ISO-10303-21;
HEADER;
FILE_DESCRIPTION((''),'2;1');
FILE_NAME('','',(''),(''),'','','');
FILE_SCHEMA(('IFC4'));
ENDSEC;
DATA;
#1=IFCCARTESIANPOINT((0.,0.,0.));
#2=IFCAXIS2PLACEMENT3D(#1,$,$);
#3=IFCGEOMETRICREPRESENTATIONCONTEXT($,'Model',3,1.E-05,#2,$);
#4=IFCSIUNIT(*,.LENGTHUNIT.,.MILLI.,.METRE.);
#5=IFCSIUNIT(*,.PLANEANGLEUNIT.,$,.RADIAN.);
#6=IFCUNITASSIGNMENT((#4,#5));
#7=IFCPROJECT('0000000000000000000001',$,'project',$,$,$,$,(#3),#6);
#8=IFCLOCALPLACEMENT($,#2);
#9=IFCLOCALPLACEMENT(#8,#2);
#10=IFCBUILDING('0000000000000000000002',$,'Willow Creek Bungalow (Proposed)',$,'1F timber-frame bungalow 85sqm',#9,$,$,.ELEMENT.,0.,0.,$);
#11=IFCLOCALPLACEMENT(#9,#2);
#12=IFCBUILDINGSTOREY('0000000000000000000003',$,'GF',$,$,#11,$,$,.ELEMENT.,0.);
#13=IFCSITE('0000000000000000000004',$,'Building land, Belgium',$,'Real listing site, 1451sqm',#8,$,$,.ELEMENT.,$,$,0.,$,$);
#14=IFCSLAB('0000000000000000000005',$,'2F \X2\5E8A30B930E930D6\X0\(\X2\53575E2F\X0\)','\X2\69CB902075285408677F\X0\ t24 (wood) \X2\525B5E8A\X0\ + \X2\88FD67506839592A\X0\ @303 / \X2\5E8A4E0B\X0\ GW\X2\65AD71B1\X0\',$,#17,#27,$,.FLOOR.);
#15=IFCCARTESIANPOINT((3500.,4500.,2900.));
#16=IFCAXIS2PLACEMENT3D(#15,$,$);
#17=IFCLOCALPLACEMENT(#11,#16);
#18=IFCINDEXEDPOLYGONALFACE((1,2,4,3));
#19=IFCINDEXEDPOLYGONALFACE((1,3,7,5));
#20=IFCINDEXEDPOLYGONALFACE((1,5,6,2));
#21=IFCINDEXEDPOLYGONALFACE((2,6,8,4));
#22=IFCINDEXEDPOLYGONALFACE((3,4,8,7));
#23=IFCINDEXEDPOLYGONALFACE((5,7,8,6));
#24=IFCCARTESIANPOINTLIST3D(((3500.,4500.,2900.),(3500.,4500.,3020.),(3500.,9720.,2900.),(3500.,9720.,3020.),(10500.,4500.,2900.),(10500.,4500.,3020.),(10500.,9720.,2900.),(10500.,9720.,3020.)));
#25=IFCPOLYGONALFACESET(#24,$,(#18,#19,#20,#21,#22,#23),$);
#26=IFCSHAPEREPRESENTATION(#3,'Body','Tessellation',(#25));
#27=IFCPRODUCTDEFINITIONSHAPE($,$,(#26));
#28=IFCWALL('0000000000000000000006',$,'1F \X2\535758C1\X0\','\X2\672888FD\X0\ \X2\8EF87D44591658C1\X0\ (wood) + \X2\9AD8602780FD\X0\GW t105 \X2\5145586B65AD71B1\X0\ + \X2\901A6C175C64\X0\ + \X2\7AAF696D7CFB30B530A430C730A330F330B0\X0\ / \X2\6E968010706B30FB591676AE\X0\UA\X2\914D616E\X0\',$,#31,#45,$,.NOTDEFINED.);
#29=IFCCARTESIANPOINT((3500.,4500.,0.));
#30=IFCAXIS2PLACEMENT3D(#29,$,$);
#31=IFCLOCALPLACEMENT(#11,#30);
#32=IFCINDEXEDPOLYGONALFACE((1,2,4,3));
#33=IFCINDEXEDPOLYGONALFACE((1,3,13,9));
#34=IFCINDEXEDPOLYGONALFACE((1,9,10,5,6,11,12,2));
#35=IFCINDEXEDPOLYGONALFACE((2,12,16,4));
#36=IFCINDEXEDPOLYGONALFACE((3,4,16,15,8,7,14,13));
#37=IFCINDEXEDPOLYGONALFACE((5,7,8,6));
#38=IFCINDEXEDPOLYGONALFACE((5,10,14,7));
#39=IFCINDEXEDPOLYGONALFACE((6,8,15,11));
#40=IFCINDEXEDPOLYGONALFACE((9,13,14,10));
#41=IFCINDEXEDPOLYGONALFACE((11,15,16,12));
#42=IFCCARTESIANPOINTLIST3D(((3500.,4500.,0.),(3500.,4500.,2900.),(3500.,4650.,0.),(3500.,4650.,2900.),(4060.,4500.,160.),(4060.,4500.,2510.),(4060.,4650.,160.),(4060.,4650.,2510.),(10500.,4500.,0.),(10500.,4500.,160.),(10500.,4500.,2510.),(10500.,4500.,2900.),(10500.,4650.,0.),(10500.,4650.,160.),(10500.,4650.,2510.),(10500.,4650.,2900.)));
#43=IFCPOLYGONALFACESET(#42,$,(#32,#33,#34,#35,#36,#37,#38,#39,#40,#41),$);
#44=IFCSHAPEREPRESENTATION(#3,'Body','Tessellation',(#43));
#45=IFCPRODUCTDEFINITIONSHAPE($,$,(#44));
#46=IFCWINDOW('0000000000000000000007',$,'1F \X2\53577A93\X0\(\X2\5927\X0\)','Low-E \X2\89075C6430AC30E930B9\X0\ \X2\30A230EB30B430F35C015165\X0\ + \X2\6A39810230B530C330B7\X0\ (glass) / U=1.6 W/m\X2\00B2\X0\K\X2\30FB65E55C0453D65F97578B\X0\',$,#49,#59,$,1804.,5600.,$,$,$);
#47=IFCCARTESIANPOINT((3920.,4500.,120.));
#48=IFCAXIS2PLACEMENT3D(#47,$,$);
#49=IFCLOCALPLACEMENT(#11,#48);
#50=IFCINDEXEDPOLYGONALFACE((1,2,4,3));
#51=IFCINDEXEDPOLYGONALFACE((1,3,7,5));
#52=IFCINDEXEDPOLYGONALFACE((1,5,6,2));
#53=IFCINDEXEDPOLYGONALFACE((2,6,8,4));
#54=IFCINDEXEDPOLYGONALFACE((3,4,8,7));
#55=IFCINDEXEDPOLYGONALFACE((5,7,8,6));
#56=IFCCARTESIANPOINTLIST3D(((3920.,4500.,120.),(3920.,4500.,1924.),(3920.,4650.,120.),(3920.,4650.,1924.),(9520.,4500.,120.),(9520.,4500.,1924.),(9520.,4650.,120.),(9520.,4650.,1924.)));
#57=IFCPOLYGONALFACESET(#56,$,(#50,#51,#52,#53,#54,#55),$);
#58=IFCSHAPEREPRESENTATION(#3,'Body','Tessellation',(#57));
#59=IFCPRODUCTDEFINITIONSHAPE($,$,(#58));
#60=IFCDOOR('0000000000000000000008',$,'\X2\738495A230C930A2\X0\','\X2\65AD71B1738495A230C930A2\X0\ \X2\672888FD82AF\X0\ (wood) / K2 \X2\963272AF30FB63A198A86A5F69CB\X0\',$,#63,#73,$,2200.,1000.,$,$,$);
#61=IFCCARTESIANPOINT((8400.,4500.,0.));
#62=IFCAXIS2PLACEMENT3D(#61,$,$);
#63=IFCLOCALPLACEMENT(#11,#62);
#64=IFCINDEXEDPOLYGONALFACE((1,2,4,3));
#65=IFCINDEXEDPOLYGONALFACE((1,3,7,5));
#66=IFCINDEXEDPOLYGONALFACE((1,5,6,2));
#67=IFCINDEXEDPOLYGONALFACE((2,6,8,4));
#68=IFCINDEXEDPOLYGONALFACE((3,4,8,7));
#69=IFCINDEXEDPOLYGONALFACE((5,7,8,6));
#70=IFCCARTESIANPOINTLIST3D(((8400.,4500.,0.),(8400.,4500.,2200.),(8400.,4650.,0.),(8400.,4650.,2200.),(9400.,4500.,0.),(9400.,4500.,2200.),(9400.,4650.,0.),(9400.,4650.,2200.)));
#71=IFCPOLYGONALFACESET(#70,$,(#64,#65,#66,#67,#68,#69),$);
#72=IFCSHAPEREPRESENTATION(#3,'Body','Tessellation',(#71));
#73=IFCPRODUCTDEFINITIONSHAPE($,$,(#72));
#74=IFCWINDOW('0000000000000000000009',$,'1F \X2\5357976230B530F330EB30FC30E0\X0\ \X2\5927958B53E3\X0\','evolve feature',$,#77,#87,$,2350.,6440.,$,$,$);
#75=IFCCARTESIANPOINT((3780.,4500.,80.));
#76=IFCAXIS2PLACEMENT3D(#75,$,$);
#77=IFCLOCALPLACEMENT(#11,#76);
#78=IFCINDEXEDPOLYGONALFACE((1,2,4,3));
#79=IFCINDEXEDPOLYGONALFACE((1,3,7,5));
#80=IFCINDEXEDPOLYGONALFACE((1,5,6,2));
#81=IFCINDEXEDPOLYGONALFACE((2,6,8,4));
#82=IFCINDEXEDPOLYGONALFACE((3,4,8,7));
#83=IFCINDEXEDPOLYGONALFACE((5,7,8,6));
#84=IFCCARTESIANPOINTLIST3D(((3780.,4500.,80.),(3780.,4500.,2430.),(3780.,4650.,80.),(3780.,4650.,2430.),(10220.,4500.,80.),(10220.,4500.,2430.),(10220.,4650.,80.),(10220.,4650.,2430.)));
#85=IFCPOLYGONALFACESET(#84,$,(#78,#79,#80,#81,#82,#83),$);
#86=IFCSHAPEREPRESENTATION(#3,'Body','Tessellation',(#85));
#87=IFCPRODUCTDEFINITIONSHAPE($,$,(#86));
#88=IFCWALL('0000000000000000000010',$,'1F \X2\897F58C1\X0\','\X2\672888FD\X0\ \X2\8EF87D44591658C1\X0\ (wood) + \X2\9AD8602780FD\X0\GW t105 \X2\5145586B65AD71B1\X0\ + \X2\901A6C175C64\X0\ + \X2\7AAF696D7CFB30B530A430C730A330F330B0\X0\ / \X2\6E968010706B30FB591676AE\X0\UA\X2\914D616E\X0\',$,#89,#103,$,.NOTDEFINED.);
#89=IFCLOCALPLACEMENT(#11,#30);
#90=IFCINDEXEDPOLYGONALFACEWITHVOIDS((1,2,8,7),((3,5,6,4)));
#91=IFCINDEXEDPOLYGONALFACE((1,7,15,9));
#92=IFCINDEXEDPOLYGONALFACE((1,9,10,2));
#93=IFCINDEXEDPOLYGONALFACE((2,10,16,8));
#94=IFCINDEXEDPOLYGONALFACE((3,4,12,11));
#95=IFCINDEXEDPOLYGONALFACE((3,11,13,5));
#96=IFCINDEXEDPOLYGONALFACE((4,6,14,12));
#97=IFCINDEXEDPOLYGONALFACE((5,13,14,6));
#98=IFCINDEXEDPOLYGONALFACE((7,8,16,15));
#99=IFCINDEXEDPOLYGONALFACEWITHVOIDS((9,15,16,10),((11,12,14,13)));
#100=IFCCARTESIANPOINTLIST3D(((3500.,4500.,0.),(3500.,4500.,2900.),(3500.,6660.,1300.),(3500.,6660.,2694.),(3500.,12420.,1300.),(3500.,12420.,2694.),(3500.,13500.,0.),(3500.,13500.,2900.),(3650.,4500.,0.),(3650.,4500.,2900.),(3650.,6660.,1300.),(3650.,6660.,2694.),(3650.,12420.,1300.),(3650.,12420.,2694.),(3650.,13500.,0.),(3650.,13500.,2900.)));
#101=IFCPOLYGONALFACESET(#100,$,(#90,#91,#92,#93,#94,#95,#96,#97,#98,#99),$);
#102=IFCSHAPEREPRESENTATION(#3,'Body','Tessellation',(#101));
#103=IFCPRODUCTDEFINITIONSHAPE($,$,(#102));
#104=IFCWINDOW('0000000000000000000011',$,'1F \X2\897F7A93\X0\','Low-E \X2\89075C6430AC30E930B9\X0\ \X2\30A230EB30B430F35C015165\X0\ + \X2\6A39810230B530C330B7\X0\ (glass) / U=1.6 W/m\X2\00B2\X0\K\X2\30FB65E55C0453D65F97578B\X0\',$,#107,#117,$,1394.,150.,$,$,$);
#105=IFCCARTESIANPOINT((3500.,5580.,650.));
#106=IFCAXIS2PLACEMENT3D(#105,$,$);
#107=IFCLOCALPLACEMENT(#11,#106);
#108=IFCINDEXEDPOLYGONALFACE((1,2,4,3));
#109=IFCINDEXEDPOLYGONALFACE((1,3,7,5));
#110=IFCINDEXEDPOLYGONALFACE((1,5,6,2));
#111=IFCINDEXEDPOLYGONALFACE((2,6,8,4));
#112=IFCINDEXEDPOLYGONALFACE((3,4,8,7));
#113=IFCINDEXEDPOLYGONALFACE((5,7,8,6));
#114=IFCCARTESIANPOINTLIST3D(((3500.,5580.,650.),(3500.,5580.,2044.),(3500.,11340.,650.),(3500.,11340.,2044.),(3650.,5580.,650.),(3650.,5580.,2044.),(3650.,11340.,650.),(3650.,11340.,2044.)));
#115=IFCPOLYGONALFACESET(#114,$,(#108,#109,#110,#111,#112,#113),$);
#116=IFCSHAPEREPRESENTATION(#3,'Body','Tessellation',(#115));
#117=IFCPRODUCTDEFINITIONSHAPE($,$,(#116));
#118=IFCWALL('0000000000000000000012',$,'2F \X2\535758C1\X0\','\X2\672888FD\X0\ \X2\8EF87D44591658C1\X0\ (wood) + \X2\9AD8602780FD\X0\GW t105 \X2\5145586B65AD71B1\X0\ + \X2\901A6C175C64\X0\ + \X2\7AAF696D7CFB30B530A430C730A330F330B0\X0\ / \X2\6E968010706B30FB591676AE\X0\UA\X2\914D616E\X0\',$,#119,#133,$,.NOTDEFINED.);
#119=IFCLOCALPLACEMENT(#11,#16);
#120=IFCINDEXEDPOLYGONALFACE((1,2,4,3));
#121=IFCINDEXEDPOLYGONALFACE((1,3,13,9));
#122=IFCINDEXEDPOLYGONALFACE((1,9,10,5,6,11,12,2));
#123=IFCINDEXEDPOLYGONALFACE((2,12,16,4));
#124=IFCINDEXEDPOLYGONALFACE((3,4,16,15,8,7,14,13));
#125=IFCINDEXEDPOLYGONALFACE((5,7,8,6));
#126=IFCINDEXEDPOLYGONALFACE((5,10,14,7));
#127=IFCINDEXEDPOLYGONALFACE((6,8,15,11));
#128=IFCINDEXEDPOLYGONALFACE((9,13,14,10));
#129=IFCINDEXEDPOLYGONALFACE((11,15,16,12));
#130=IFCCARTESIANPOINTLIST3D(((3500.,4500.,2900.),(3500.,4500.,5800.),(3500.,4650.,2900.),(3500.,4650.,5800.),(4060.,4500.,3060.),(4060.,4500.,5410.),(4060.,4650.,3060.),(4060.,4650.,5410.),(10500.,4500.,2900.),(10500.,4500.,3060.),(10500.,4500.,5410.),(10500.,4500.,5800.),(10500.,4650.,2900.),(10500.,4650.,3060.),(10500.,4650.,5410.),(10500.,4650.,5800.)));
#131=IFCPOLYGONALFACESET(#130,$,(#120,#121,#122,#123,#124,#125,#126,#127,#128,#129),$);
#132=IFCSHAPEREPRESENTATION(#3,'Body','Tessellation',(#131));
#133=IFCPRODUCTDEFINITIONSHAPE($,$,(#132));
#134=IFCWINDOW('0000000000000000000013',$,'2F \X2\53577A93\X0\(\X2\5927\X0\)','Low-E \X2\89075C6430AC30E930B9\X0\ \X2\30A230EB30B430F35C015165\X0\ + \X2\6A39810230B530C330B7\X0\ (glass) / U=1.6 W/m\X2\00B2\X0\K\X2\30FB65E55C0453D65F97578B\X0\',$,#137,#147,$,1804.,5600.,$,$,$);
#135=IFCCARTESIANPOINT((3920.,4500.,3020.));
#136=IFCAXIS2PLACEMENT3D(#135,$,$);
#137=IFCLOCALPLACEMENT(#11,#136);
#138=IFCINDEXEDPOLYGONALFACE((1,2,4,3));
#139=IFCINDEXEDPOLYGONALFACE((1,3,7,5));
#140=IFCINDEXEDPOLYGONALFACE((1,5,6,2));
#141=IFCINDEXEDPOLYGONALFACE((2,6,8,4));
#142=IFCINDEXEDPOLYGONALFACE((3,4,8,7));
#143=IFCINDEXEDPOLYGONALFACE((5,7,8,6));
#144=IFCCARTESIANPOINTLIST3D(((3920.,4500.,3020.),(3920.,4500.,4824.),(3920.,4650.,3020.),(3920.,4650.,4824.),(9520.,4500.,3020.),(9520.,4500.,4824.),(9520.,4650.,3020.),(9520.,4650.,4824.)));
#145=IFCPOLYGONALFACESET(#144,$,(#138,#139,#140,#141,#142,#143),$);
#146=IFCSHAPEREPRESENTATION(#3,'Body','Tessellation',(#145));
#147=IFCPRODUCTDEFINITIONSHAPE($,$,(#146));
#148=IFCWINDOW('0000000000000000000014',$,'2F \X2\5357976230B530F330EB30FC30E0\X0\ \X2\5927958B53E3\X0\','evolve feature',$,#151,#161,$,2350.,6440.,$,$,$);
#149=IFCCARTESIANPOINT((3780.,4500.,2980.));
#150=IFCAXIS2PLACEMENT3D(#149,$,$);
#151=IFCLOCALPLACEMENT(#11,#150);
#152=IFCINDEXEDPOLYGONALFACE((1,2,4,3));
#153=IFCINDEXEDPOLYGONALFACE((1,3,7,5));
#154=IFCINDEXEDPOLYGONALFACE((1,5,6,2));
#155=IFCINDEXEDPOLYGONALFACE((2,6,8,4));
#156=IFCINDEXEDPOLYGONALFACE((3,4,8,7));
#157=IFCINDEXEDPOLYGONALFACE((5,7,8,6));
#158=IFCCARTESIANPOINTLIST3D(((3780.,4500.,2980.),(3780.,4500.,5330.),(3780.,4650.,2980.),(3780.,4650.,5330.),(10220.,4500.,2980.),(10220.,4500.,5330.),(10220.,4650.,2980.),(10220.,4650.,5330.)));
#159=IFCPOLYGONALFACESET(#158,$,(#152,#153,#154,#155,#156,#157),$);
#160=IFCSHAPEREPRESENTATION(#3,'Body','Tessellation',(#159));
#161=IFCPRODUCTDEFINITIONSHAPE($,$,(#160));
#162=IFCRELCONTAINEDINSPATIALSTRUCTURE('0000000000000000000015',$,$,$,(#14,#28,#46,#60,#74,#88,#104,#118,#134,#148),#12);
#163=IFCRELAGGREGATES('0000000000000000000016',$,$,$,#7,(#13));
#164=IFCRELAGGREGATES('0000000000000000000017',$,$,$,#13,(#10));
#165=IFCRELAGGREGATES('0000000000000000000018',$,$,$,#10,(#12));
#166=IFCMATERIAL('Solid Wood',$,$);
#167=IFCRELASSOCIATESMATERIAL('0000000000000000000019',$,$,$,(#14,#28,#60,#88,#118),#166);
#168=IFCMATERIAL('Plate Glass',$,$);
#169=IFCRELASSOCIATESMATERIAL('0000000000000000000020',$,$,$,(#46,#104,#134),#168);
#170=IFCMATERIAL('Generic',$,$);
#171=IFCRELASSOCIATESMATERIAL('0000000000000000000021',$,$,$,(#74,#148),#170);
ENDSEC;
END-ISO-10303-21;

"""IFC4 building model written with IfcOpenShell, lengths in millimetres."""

from ifc_helpers import new_model, si_unit, frame, frame_2d, origin, place, context, project, spatial, rectangle, extrude, material, element, fill, save


model = new_model("IFC4")

# Units and contexts
model_context = context("Model", 3, precision=1e-05, world=origin())
ifc_project = project(units=[si_unit("LENGTHUNIT", "METRE", prefix="MILLI"), si_unit("PLANEANGLEUNIT", "RADIAN")], contexts=[model_context])

# Site, building, storey
site_placement = place(None, origin())
site = spatial("IfcSite", under=ifc_project, at=site_placement, Name="Building land, Belgium", ObjectType="Real listing site, 1451sqm", CompositionType="ELEMENT", RefElevation=0.0)
building_placement = place(site_placement, origin())
building = spatial("IfcBuilding", under=site, at=building_placement, Name="Willow Creek Bungalow (Proposed)", ObjectType="1F timber-frame bungalow 85sqm", CompositionType="ELEMENT", ElevationOfRefHeight=0.0, ElevationOfTerrain=0.0)
storey_placement = place(building_placement, origin())
storey = spatial("IfcBuildingStorey", under=building, at=storey_placement, Name="GF", CompositionType="ELEMENT", Elevation=0.0)

# Slab
ifc_material_1 = material(Name="Solid Wood")
slab_1_placement = place(storey_placement, frame((3500.0, 4500.0, 2900.0)))
element("IfcSlab", 1, at=slab_1_placement, inside=storey, material=ifc_material_1, Name="2F 床スラブ(南帯)", Description="構造用合板 t24 (wood) 剛床 + 製材根太 @303 / 床下 GW断熱", PredefinedType="FLOOR", context=model_context, shape_type="SweptSolid", body=[
    extrude(rectangle(XDim=7000.0, YDim=5220.0, at=frame_2d((3500.0, 2610.0))), frame((3500.0, 4500.0, 2900.0)), (0.0, 0.0, 1.0), 120.0),
])
ifc_material_2 = material(Name="Generic")

# Wall, openings, windows, door
wall_1_placement = place(storey_placement, frame((3500.0, 4500.0, 0.0)))
wall_1 = element("IfcWall", 2, at=wall_1_placement, inside=storey, material=ifc_material_1, Name="1F 南壁", Description="木製 軸組外壁 (wood) + 高性能GW t105 充填断熱 + 通気層 + 窯業系サイディング / 準耐火・外皮UA配慮", PredefinedType="NOTDEFINED", context=model_context, shape_type="SweptSolid", body=[
    extrude(rectangle(XDim=7000.0, YDim=150.0, at=frame_2d((3500.0, 75.0))), frame((3500.0, 4500.0, 0.0)), (0.0, 0.0, 1.0), 2900.0),
])
opening_1_placement = place(storey_placement, frame((3920.0, 4500.0, 120.0)))
opening_1 = element("IfcOpeningElement", 3, at=opening_1_placement, cuts=wall_1, PredefinedType="NOTDEFINED", context=model_context, shape_type="SweptSolid", body=[
    extrude(rectangle(XDim=5600.0, YDim=150.0, at=frame_2d((2800.0, 75.0))), frame((3920.0, 4500.0, 120.0)), (0.0, 0.0, 1.0), 1804.0),
])
opening_2_placement = place(storey_placement, frame((8400.0, 4500.0, 0.0)))
opening_2 = element("IfcOpeningElement", 4, at=opening_2_placement, cuts=wall_1, PredefinedType="NOTDEFINED", context=model_context, shape_type="SweptSolid", body=[
    extrude(rectangle(XDim=1000.0, YDim=150.0, at=frame_2d((500.0, 75.0))), frame((8400.0, 4500.0, 0.0)), (0.0, 0.0, 1.0), 2200.0),
])
opening_3_placement = place(storey_placement, frame((3780.0, 4500.0, 80.0)))
opening_3 = element("IfcOpeningElement", 5, at=opening_3_placement, cuts=wall_1, PredefinedType="NOTDEFINED", context=model_context, shape_type="SweptSolid", body=[
    extrude(rectangle(XDim=6440.0, YDim=150.0, at=frame_2d((3220.0, 75.0))), frame((3780.0, 4500.0, 80.0)), (0.0, 0.0, 1.0), 2350.0),
])
ifc_material_3 = material(Name="Plate Glass")
window_1_placement = place(storey_placement, frame((3920.0, 4500.0, 120.0)))
window_1 = element("IfcWindow", 6, at=window_1_placement, inside=storey, material=ifc_material_3, Name="1F 南窓(大)", Description="Low-E 複層ガラス アルゴン封入 + 樹脂サッシ (glass) / U=1.6 W/m²K・日射取得型", OverallHeight=1804.0, OverallWidth=5600.0, context=model_context, shape_type="SweptSolid", body=[
    extrude(rectangle(XDim=5600.0, YDim=150.0, at=frame_2d((2800.0, 75.0))), frame((3920.0, 4500.0, 120.0)), (0.0, 0.0, 1.0), 1804.0),
])
fill(opening_1, window_1)
door_placement = place(storey_placement, frame((8400.0, 4500.0, 0.0)))
door = element("IfcDoor", 7, at=door_placement, inside=storey, material=ifc_material_1, Name="玄関ドア", Description="断熱玄関ドア 木製芯 (wood) / K2 防犯・採風機構", OverallHeight=2200.0, OverallWidth=1000.0, context=model_context, shape_type="SweptSolid", body=[
    extrude(rectangle(XDim=1000.0, YDim=150.0, at=frame_2d((500.0, 75.0))), frame((8400.0, 4500.0, 0.0)), (0.0, 0.0, 1.0), 2200.0),
])
fill(opening_2, door)
window_2_placement = place(storey_placement, frame((3780.0, 4500.0, 80.0)))
window_2 = element("IfcWindow", 8, at=window_2_placement, inside=storey, material=ifc_material_2, Name="1F 南面サンルーム 大開口", Description="evolve feature", OverallHeight=2350.0, OverallWidth=6440.0, context=model_context, shape_type="SweptSolid", body=[
    extrude(rectangle(XDim=6440.0, YDim=150.0, at=frame_2d((3220.0, 75.0))), frame((3780.0, 4500.0, 80.0)), (0.0, 0.0, 1.0), 2350.0),
])
fill(opening_3, window_2)

# Wall, opening, window
wall_2_placement = place(storey_placement, frame((3500.0, 4500.0, 0.0)))
wall_2 = element("IfcWall", 9, at=wall_2_placement, inside=storey, material=ifc_material_1, Name="1F 西壁", Description="木製 軸組外壁 (wood) + 高性能GW t105 充填断熱 + 通気層 + 窯業系サイディング / 準耐火・外皮UA配慮", PredefinedType="NOTDEFINED", context=model_context, shape_type="SweptSolid", body=[
    extrude(rectangle(XDim=150.0, YDim=9000.0, at=frame_2d((75.0, 4500.0))), frame((3500.0, 4500.0, 0.0)), (0.0, 0.0, 1.0), 2900.0),
])
opening_4_placement = place(storey_placement, frame((3500.0, 5580.0, 650.0)))
opening_4 = element("IfcOpeningElement", 10, at=opening_4_placement, cuts=wall_2, PredefinedType="NOTDEFINED", context=model_context, shape_type="SweptSolid", body=[
    extrude(rectangle(XDim=150.0, YDim=5760.0, at=frame_2d((75.0, 2880.0))), frame((3500.0, 5580.0, 650.0)), (0.0, 0.0, 1.0), 1394.0),
])
window_3_placement = place(storey_placement, frame((3500.0, 5580.0, 650.0)))
window_3 = element("IfcWindow", 11, at=window_3_placement, inside=storey, material=ifc_material_3, Name="1F 西窓", Description="Low-E 複層ガラス アルゴン封入 + 樹脂サッシ (glass) / U=1.6 W/m²K・日射取得型", OverallHeight=1394.0, OverallWidth=150.0, context=model_context, shape_type="SweptSolid", body=[
    extrude(rectangle(XDim=150.0, YDim=5760.0, at=frame_2d((75.0, 2880.0))), frame((3500.0, 5580.0, 650.0)), (0.0, 0.0, 1.0), 1394.0),
])
fill(opening_4, window_3)

# Wall, openings, windows
wall_3_placement = place(storey_placement, frame((3500.0, 4500.0, 2900.0)))
wall_3 = element("IfcWall", 12, at=wall_3_placement, inside=storey, material=ifc_material_1, Name="2F 南壁", Description="木製 軸組外壁 (wood) + 高性能GW t105 充填断熱 + 通気層 + 窯業系サイディング / 準耐火・外皮UA配慮", PredefinedType="NOTDEFINED", context=model_context, shape_type="SweptSolid", body=[
    extrude(rectangle(XDim=7000.0, YDim=150.0, at=frame_2d((3500.0, 75.0))), frame((3500.0, 4500.0, 2900.0)), (0.0, 0.0, 1.0), 2900.0),
])
opening_5_placement = place(storey_placement, frame((3920.0, 4500.0, 3020.0)))
opening_5 = element("IfcOpeningElement", 13, at=opening_5_placement, cuts=wall_3, PredefinedType="NOTDEFINED", context=model_context, shape_type="SweptSolid", body=[
    extrude(rectangle(XDim=5600.0, YDim=150.0, at=frame_2d((2800.0, 75.0))), frame((3920.0, 4500.0, 3020.0)), (0.0, 0.0, 1.0), 1804.0),
])
opening_6_placement = place(storey_placement, frame((3780.0, 4500.0, 2980.0)))
opening_6 = element("IfcOpeningElement", 14, at=opening_6_placement, cuts=wall_3, PredefinedType="NOTDEFINED", context=model_context, shape_type="SweptSolid", body=[
    extrude(rectangle(XDim=6440.0, YDim=150.0, at=frame_2d((3220.0, 75.0))), frame((3780.0, 4500.0, 2980.0)), (0.0, 0.0, 1.0), 2350.0),
])
window_4_placement = place(storey_placement, frame((3920.0, 4500.0, 3020.0)))
window_4 = element("IfcWindow", 15, at=window_4_placement, inside=storey, material=ifc_material_3, Name="2F 南窓(大)", Description="Low-E 複層ガラス アルゴン封入 + 樹脂サッシ (glass) / U=1.6 W/m²K・日射取得型", OverallHeight=1804.0, OverallWidth=5600.0, context=model_context, shape_type="SweptSolid", body=[
    extrude(rectangle(XDim=5600.0, YDim=150.0, at=frame_2d((2800.0, 75.0))), frame((3920.0, 4500.0, 3020.0)), (0.0, 0.0, 1.0), 1804.0),
])
fill(opening_5, window_4)
window_5_placement = place(storey_placement, frame((3780.0, 4500.0, 2980.0)))
window_5 = element("IfcWindow", 16, at=window_5_placement, inside=storey, material=ifc_material_2, Name="2F 南面サンルーム 大開口", Description="evolve feature", OverallHeight=2350.0, OverallWidth=6440.0, context=model_context, shape_type="SweptSolid", body=[
    extrude(rectangle(XDim=6440.0, YDim=150.0, at=frame_2d((3220.0, 75.0))), frame((3780.0, 4500.0, 2980.0)), (0.0, 0.0, 1.0), 2350.0),
])
fill(opening_6, window_5)

save(model, "model.ifc")
